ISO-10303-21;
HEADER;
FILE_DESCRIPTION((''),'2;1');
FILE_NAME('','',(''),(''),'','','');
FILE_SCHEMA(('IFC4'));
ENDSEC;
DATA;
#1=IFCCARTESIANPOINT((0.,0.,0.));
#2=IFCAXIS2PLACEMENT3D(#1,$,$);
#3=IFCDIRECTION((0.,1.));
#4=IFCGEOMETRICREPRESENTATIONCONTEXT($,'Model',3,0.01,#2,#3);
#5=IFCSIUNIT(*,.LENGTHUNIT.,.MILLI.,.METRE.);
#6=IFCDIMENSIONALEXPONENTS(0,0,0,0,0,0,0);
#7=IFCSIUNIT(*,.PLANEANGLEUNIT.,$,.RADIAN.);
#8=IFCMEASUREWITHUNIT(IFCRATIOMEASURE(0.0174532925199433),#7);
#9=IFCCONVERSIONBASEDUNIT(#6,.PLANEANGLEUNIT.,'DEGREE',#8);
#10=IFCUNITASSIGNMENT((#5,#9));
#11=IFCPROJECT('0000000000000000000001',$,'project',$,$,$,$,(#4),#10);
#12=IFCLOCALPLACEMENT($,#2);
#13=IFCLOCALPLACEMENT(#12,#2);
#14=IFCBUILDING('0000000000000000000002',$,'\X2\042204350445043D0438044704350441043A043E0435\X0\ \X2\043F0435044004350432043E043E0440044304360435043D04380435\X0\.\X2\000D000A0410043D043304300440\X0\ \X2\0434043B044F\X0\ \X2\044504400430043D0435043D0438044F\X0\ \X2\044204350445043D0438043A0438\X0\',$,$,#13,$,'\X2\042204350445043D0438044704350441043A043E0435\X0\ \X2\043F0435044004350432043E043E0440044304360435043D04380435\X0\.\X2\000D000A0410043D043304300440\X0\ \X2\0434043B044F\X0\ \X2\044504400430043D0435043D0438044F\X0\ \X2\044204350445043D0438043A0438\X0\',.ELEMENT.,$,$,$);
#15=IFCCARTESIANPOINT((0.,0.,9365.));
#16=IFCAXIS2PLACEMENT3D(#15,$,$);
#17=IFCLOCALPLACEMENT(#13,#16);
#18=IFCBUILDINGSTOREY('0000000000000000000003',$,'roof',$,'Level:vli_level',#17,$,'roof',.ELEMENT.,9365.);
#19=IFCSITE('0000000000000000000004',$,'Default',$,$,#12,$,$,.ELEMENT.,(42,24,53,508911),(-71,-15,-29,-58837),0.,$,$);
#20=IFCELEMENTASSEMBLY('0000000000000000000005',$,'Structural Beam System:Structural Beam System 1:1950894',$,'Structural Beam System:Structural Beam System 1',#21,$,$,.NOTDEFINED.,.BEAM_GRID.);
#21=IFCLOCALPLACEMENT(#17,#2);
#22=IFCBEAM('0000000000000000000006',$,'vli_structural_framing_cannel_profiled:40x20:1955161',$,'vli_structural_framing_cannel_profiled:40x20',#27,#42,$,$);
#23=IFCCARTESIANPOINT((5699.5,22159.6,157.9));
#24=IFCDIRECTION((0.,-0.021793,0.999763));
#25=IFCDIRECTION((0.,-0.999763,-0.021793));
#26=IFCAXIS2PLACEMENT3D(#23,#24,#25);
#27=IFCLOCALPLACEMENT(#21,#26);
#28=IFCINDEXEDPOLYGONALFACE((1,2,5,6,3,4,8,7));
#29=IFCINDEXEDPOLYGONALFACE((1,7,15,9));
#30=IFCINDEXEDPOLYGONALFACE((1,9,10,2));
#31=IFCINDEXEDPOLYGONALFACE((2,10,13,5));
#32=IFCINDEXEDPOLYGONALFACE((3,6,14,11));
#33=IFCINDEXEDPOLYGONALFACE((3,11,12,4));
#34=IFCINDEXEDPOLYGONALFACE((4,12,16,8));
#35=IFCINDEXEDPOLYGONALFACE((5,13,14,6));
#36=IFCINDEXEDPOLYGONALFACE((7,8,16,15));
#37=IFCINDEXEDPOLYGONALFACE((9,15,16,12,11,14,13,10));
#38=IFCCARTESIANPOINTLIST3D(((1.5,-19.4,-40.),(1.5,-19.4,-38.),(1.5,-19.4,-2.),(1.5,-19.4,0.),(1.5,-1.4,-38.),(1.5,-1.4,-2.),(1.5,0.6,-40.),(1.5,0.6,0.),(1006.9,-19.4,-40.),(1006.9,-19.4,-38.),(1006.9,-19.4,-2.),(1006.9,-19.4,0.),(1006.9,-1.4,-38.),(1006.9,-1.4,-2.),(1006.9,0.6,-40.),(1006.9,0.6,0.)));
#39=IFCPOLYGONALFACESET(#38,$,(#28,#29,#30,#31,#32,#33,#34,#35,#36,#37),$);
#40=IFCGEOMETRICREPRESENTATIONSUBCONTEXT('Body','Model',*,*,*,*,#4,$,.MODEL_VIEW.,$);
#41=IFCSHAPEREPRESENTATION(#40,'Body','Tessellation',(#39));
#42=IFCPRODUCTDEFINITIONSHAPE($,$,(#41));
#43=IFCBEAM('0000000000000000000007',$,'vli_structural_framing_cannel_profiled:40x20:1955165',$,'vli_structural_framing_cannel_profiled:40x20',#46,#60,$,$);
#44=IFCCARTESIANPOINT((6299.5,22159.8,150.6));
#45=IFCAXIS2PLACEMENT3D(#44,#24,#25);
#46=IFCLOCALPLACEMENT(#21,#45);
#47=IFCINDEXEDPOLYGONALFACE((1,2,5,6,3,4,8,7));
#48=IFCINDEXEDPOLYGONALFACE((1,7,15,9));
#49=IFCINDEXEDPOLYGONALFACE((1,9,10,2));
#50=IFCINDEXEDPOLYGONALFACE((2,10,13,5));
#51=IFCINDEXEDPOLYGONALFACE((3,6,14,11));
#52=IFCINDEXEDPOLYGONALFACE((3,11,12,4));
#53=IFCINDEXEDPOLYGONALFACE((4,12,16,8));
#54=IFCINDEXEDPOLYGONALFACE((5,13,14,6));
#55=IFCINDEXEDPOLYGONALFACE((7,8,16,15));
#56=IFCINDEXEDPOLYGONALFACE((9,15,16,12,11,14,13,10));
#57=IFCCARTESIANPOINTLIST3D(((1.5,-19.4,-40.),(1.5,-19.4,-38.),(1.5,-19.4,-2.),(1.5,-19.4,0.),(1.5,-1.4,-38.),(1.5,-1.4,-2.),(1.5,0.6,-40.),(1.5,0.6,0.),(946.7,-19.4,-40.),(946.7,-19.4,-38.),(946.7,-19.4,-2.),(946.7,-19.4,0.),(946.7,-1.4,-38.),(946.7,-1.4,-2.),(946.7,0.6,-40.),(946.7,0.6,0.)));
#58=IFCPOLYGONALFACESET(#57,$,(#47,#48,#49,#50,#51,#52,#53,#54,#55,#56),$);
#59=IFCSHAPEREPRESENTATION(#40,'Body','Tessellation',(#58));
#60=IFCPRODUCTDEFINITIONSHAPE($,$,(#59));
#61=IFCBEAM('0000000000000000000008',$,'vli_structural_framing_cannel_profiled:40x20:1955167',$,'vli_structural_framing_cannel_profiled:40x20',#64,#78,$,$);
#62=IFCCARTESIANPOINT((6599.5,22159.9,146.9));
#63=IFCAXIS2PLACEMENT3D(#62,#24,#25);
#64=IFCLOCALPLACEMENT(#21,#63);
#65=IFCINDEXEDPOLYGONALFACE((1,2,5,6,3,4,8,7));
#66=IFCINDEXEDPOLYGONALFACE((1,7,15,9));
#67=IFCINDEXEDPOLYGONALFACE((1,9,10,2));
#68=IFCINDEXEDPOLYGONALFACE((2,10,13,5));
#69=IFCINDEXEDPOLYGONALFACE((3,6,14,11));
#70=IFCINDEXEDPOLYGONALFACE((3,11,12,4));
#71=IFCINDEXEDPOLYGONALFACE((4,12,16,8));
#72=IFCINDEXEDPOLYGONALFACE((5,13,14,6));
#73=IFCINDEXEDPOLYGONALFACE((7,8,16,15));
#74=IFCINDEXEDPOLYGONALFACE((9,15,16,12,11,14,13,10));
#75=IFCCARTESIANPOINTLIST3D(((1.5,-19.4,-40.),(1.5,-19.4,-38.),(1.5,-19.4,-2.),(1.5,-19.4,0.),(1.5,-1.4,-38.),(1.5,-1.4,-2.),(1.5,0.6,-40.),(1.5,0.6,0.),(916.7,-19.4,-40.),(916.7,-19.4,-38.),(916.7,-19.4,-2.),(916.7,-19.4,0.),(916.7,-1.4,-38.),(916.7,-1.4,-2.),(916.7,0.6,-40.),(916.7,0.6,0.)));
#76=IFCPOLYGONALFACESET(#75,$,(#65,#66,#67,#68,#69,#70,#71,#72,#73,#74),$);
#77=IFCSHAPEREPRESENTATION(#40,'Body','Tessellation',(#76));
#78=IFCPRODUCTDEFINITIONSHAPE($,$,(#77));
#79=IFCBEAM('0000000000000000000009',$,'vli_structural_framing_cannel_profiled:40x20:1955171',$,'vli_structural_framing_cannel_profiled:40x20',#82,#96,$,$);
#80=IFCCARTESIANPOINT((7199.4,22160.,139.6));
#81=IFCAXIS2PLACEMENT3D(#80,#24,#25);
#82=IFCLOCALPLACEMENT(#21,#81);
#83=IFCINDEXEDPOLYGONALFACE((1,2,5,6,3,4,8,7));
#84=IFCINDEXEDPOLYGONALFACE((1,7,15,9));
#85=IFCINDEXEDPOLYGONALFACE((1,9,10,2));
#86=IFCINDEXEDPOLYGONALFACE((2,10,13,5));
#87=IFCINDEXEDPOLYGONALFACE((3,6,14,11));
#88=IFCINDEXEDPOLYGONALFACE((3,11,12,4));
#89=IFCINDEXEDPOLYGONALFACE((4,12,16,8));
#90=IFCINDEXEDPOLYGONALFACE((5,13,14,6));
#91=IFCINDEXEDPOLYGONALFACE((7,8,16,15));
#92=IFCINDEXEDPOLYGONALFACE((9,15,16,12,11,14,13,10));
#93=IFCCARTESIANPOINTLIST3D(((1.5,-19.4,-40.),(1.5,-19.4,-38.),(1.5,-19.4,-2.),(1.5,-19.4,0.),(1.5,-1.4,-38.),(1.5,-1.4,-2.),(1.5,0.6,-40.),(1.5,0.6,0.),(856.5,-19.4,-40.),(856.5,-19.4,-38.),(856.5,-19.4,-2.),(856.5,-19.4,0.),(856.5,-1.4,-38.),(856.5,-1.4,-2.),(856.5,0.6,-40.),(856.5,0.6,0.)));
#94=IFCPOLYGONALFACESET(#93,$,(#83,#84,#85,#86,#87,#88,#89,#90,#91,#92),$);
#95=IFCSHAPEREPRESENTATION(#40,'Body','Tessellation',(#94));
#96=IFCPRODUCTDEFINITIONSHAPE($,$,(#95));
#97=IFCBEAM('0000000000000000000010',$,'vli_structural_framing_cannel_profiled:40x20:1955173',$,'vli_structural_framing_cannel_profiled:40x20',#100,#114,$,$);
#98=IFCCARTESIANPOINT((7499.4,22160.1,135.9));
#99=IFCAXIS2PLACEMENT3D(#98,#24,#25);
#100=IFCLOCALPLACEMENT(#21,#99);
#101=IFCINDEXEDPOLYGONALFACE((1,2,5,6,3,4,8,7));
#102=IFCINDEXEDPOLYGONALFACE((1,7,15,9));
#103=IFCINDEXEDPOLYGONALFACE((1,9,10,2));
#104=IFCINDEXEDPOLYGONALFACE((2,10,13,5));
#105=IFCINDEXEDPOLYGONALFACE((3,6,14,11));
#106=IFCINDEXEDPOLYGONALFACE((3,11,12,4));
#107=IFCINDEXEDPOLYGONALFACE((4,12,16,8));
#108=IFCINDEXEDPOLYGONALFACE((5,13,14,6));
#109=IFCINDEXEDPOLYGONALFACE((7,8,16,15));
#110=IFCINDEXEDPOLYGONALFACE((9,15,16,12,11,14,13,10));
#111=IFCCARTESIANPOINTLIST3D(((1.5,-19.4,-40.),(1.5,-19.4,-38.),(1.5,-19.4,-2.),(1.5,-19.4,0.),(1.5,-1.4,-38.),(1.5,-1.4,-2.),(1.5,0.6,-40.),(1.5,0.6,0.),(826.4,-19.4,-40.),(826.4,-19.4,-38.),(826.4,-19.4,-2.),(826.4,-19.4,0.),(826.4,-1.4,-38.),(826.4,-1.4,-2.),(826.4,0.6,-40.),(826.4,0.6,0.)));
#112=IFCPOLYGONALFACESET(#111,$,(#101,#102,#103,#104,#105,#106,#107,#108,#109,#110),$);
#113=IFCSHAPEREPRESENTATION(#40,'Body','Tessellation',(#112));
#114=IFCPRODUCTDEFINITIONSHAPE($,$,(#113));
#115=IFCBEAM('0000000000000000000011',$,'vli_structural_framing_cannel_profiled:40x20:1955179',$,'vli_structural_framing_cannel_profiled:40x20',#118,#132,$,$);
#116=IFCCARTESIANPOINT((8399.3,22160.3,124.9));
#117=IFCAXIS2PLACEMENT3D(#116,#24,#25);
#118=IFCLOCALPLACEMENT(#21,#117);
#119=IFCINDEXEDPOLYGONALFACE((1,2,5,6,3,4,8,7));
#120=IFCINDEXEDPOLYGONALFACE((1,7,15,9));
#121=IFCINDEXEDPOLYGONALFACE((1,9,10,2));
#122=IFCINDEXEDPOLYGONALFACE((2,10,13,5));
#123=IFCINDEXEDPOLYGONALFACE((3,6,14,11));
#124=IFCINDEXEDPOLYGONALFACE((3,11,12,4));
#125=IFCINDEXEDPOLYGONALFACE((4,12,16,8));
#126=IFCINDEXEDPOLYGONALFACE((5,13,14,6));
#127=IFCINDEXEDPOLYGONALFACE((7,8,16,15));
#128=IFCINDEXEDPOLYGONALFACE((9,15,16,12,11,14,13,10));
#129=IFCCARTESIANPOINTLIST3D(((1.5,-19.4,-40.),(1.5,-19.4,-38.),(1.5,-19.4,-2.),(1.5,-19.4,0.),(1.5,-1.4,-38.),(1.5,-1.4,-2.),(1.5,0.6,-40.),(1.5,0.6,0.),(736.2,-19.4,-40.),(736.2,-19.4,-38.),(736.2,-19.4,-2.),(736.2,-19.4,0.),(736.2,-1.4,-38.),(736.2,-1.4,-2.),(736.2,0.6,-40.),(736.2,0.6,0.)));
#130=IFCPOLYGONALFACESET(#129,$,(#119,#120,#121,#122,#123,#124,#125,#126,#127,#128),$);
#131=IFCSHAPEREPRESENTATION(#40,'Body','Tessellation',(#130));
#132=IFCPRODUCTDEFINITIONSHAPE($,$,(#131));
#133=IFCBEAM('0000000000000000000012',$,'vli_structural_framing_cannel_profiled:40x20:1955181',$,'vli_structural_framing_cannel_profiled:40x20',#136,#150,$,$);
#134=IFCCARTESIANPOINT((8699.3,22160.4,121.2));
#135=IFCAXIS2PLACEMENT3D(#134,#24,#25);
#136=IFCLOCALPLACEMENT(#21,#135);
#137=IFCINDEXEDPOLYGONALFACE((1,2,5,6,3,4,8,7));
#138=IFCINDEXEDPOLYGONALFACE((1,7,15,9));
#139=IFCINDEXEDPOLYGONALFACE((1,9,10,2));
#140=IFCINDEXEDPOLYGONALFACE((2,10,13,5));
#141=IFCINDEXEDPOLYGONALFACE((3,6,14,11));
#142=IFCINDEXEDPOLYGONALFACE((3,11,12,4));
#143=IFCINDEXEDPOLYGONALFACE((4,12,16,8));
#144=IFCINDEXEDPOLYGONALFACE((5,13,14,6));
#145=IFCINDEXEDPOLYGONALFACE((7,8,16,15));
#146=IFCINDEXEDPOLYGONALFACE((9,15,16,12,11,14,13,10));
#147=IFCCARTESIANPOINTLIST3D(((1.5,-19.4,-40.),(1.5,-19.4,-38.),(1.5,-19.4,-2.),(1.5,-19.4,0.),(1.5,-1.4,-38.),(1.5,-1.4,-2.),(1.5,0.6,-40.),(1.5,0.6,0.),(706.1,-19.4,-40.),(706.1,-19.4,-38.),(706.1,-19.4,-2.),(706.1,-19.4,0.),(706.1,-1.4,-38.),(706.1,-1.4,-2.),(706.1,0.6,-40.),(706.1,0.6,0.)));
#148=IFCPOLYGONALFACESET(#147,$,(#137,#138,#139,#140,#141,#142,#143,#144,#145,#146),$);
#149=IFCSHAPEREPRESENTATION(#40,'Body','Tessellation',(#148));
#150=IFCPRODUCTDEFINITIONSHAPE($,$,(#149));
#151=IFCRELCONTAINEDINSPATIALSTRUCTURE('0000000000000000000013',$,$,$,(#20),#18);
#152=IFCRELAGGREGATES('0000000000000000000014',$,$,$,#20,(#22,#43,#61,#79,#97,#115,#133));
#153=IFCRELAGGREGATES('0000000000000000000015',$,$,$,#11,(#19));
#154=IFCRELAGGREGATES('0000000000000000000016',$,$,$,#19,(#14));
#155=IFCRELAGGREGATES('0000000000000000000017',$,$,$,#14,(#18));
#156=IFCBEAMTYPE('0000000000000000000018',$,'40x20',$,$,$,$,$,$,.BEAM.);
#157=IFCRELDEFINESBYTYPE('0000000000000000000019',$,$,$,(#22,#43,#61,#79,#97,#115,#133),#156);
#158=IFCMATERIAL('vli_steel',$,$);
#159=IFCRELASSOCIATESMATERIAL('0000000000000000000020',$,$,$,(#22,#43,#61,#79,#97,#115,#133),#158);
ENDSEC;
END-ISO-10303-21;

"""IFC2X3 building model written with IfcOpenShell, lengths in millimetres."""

from ifc_helpers import new_model, entity, si_unit, converted_unit, direction, frame, origin, place, context, subcontext, project, spatial, polyline, outline, extrude, material, type_object, element, aggregate, save


model = new_model("IFC2X3")

# Units and contexts
model_context = context("Model", 3, precision=0.01, world=origin(), true_north=direction((0.0, 1.0)))
body_context = subcontext(model_context, "Body", "Model", "MODEL_VIEW")
ifc_project = project(units=[si_unit("LENGTHUNIT", "METRE", prefix="MILLI"), converted_unit("PLANEANGLEUNIT", "DEGREE", entity("IfcRatioMeasure", 0.0174532925199433), si_unit("PLANEANGLEUNIT", "RADIAN"), dimensions=[0, 0, 0, 0, 0, 0, 0])], contexts=[model_context])

# Site, building, storey
site_placement = place(None, origin())
site = spatial("IfcSite", under=ifc_project, at=site_placement, Name="Default", CompositionType="ELEMENT", RefLatitude=(42, 24, 53, 508911), RefLongitude=(-71, -15, -29, -58837), RefElevation=0.0)
building_placement = place(site_placement, origin())
building = spatial("IfcBuilding", under=site, at=building_placement, Name="Техническое перевооружение.\r\nАнгар для хранения техники", LongName="Техническое перевооружение.\r\nАнгар для хранения техники", CompositionType="ELEMENT")
storey_placement = place(building_placement, frame((0.0, 0.0, 9365.0)))
storey = spatial("IfcBuildingStorey", under=building, at=storey_placement, Name="roof", ObjectType="Level:vli_level", LongName="roof", CompositionType="ELEMENT", Elevation=9365.0)

# Element assembly, beams
ifc_material = material(Name="vli_steel")
beam_type = type_object("IfcBeamType", Name="40x20", PredefinedType="BEAM")
assembly_1_placement = place(storey_placement, origin())
assembly_1 = element("IfcElementAssembly", 1, at=assembly_1_placement, inside=storey, Name="Structural Beam System:Structural Beam System 1:1950894", ObjectType="Structural Beam System:Structural Beam System 1", AssemblyPlace="NOTDEFINED", PredefinedType="BEAM_GRID")
beam_1_placement = place(assembly_1_placement, frame((5699.5, 22159.6, 157.9), z_axis=(0.0, -0.021793, 0.999763), x_axis=(0.0, -0.999763, -0.021793)))
beam_1 = element("IfcBeam", 2, at=beam_1_placement, type_object=beam_type, material=ifc_material, Name="vli_structural_framing_cannel_profiled:40x20:1955161", ObjectType="vli_structural_framing_cannel_profiled:40x20", context=body_context, shape_type="SweptSolid", body=[
    extrude(outline(polyline([(-20.0, -9.5), (-18.0, -9.5), (-18.0, 8.5), (18.0, 8.5), (18.0, -9.5), (20.0, -9.5), (20.0, 10.5), (-20.0, 10.5), (-20.0, -9.5)])), frame((1.5, -9.9, -20.0), z_axis=(1.0, 0.0, 0.0), x_axis=(0.0, 0.0, -1.0)), (0.0, 0.0, 1.0), 1005.4),
])
beam_2_placement = place(assembly_1_placement, frame((6299.5, 22159.8, 150.6), z_axis=(0.0, -0.021793, 0.999763), x_axis=(0.0, -0.999763, -0.021793)))
beam_2 = element("IfcBeam", 3, at=beam_2_placement, type_object=beam_type, material=ifc_material, Name="vli_structural_framing_cannel_profiled:40x20:1955165", ObjectType="vli_structural_framing_cannel_profiled:40x20", context=body_context, shape_type="SweptSolid", body=[
    extrude(outline(polyline([(-20.0, -9.5), (-18.0, -9.5), (-18.0, 8.5), (18.0, 8.5), (18.0, -9.5), (20.0, -9.5), (20.0, 10.5), (-20.0, 10.5), (-20.0, -9.5)])), frame((1.5, -9.9, -20.0), z_axis=(1.0, 0.0, 0.0), x_axis=(0.0, 0.0, -1.0)), (0.0, 0.0, 1.0), 945.3),
])
beam_3_placement = place(assembly_1_placement, frame((6599.5, 22159.9, 146.9), z_axis=(0.0, -0.021793, 0.999763), x_axis=(0.0, -0.999763, -0.021793)))
beam_3 = element("IfcBeam", 4, at=beam_3_placement, type_object=beam_type, material=ifc_material, Name="vli_structural_framing_cannel_profiled:40x20:1955167", ObjectType="vli_structural_framing_cannel_profiled:40x20", context=body_context, shape_type="SweptSolid", body=[
    extrude(outline(polyline([(-20.0, -9.5), (-18.0, -9.5), (-18.0, 8.5), (18.0, 8.5), (18.0, -9.5), (20.0, -9.5), (20.0, 10.5), (-20.0, 10.5), (-20.0, -9.5)])), frame((1.5, -9.9, -20.0), z_axis=(1.0, 0.0, 0.0), x_axis=(0.0, 0.0, -1.0)), (0.0, 0.0, 1.0), 915.2),
])
beam_4_placement = place(assembly_1_placement, frame((7199.4, 22160.0, 139.6), z_axis=(0.0, -0.021793, 0.999763), x_axis=(0.0, -0.999763, -0.021793)))
beam_4 = element("IfcBeam", 5, at=beam_4_placement, type_object=beam_type, material=ifc_material, Name="vli_structural_framing_cannel_profiled:40x20:1955171", ObjectType="vli_structural_framing_cannel_profiled:40x20", context=body_context, shape_type="SweptSolid", body=[
    extrude(outline(polyline([(-20.0, -9.5), (-18.0, -9.5), (-18.0, 8.5), (18.0, 8.5), (18.0, -9.5), (20.0, -9.5), (20.0, 10.5), (-20.0, 10.5), (-20.0, -9.5)])), frame((1.5, -9.9, -20.0), z_axis=(1.0, 0.0, 0.0), x_axis=(0.0, 0.0, -1.0)), (0.0, 0.0, 1.0), 855.0),
])
beam_5_placement = place(assembly_1_placement, frame((7499.4, 22160.1, 135.9), z_axis=(0.0, -0.021793, 0.999763), x_axis=(0.0, -0.999763, -0.021793)))
beam_5 = element("IfcBeam", 6, at=beam_5_placement, type_object=beam_type, material=ifc_material, Name="vli_structural_framing_cannel_profiled:40x20:1955173", ObjectType="vli_structural_framing_cannel_profiled:40x20", context=body_context, shape_type="SweptSolid", body=[
    extrude(outline(polyline([(-20.0, -9.5), (-18.0, -9.5), (-18.0, 8.5), (18.0, 8.5), (18.0, -9.5), (20.0, -9.5), (20.0, 10.5), (-20.0, 10.5), (-20.0, -9.5)])), frame((1.5, -9.9, -20.0), z_axis=(1.0, 0.0, 0.0), x_axis=(0.0, 0.0, -1.0)), (0.0, 0.0, 1.0), 825.0),
])
beam_6_placement = place(assembly_1_placement, frame((8399.3, 22160.3, 124.9), z_axis=(0.0, -0.021793, 0.999763), x_axis=(0.0, -0.999763, -0.021793)))
beam_6 = element("IfcBeam", 7, at=beam_6_placement, type_object=beam_type, material=ifc_material, Name="vli_structural_framing_cannel_profiled:40x20:1955179", ObjectType="vli_structural_framing_cannel_profiled:40x20", context=body_context, shape_type="SweptSolid", body=[
    extrude(outline(polyline([(-20.0, -9.5), (-18.0, -9.5), (-18.0, 8.5), (18.0, 8.5), (18.0, -9.5), (20.0, -9.5), (20.0, 10.5), (-20.0, 10.5), (-20.0, -9.5)])), frame((1.5, -9.9, -20.0), z_axis=(1.0, 0.0, 0.0), x_axis=(0.0, 0.0, -1.0)), (0.0, 0.0, 1.0), 734.7),
])
beam_7_placement = place(assembly_1_placement, frame((8699.3, 22160.4, 121.2), z_axis=(0.0, -0.021793, 0.999763), x_axis=(0.0, -0.999763, -0.021793)))
beam_7 = element("IfcBeam", 8, at=beam_7_placement, type_object=beam_type, material=ifc_material, Name="vli_structural_framing_cannel_profiled:40x20:1955181", ObjectType="vli_structural_framing_cannel_profiled:40x20", context=body_context, shape_type="SweptSolid", body=[
    extrude(outline(polyline([(-20.0, -9.5), (-18.0, -9.5), (-18.0, 8.5), (18.0, 8.5), (18.0, -9.5), (20.0, -9.5), (20.0, 10.5), (-20.0, 10.5), (-20.0, -9.5)])), frame((1.5, -9.9, -20.0), z_axis=(1.0, 0.0, 0.0), x_axis=(0.0, 0.0, -1.0)), (0.0, 0.0, 1.0), 704.7),
])
aggregate(assembly_1, [beam_1, beam_2, beam_3, beam_4, beam_5, beam_6, beam_7])

save(model, "model.ifc")
